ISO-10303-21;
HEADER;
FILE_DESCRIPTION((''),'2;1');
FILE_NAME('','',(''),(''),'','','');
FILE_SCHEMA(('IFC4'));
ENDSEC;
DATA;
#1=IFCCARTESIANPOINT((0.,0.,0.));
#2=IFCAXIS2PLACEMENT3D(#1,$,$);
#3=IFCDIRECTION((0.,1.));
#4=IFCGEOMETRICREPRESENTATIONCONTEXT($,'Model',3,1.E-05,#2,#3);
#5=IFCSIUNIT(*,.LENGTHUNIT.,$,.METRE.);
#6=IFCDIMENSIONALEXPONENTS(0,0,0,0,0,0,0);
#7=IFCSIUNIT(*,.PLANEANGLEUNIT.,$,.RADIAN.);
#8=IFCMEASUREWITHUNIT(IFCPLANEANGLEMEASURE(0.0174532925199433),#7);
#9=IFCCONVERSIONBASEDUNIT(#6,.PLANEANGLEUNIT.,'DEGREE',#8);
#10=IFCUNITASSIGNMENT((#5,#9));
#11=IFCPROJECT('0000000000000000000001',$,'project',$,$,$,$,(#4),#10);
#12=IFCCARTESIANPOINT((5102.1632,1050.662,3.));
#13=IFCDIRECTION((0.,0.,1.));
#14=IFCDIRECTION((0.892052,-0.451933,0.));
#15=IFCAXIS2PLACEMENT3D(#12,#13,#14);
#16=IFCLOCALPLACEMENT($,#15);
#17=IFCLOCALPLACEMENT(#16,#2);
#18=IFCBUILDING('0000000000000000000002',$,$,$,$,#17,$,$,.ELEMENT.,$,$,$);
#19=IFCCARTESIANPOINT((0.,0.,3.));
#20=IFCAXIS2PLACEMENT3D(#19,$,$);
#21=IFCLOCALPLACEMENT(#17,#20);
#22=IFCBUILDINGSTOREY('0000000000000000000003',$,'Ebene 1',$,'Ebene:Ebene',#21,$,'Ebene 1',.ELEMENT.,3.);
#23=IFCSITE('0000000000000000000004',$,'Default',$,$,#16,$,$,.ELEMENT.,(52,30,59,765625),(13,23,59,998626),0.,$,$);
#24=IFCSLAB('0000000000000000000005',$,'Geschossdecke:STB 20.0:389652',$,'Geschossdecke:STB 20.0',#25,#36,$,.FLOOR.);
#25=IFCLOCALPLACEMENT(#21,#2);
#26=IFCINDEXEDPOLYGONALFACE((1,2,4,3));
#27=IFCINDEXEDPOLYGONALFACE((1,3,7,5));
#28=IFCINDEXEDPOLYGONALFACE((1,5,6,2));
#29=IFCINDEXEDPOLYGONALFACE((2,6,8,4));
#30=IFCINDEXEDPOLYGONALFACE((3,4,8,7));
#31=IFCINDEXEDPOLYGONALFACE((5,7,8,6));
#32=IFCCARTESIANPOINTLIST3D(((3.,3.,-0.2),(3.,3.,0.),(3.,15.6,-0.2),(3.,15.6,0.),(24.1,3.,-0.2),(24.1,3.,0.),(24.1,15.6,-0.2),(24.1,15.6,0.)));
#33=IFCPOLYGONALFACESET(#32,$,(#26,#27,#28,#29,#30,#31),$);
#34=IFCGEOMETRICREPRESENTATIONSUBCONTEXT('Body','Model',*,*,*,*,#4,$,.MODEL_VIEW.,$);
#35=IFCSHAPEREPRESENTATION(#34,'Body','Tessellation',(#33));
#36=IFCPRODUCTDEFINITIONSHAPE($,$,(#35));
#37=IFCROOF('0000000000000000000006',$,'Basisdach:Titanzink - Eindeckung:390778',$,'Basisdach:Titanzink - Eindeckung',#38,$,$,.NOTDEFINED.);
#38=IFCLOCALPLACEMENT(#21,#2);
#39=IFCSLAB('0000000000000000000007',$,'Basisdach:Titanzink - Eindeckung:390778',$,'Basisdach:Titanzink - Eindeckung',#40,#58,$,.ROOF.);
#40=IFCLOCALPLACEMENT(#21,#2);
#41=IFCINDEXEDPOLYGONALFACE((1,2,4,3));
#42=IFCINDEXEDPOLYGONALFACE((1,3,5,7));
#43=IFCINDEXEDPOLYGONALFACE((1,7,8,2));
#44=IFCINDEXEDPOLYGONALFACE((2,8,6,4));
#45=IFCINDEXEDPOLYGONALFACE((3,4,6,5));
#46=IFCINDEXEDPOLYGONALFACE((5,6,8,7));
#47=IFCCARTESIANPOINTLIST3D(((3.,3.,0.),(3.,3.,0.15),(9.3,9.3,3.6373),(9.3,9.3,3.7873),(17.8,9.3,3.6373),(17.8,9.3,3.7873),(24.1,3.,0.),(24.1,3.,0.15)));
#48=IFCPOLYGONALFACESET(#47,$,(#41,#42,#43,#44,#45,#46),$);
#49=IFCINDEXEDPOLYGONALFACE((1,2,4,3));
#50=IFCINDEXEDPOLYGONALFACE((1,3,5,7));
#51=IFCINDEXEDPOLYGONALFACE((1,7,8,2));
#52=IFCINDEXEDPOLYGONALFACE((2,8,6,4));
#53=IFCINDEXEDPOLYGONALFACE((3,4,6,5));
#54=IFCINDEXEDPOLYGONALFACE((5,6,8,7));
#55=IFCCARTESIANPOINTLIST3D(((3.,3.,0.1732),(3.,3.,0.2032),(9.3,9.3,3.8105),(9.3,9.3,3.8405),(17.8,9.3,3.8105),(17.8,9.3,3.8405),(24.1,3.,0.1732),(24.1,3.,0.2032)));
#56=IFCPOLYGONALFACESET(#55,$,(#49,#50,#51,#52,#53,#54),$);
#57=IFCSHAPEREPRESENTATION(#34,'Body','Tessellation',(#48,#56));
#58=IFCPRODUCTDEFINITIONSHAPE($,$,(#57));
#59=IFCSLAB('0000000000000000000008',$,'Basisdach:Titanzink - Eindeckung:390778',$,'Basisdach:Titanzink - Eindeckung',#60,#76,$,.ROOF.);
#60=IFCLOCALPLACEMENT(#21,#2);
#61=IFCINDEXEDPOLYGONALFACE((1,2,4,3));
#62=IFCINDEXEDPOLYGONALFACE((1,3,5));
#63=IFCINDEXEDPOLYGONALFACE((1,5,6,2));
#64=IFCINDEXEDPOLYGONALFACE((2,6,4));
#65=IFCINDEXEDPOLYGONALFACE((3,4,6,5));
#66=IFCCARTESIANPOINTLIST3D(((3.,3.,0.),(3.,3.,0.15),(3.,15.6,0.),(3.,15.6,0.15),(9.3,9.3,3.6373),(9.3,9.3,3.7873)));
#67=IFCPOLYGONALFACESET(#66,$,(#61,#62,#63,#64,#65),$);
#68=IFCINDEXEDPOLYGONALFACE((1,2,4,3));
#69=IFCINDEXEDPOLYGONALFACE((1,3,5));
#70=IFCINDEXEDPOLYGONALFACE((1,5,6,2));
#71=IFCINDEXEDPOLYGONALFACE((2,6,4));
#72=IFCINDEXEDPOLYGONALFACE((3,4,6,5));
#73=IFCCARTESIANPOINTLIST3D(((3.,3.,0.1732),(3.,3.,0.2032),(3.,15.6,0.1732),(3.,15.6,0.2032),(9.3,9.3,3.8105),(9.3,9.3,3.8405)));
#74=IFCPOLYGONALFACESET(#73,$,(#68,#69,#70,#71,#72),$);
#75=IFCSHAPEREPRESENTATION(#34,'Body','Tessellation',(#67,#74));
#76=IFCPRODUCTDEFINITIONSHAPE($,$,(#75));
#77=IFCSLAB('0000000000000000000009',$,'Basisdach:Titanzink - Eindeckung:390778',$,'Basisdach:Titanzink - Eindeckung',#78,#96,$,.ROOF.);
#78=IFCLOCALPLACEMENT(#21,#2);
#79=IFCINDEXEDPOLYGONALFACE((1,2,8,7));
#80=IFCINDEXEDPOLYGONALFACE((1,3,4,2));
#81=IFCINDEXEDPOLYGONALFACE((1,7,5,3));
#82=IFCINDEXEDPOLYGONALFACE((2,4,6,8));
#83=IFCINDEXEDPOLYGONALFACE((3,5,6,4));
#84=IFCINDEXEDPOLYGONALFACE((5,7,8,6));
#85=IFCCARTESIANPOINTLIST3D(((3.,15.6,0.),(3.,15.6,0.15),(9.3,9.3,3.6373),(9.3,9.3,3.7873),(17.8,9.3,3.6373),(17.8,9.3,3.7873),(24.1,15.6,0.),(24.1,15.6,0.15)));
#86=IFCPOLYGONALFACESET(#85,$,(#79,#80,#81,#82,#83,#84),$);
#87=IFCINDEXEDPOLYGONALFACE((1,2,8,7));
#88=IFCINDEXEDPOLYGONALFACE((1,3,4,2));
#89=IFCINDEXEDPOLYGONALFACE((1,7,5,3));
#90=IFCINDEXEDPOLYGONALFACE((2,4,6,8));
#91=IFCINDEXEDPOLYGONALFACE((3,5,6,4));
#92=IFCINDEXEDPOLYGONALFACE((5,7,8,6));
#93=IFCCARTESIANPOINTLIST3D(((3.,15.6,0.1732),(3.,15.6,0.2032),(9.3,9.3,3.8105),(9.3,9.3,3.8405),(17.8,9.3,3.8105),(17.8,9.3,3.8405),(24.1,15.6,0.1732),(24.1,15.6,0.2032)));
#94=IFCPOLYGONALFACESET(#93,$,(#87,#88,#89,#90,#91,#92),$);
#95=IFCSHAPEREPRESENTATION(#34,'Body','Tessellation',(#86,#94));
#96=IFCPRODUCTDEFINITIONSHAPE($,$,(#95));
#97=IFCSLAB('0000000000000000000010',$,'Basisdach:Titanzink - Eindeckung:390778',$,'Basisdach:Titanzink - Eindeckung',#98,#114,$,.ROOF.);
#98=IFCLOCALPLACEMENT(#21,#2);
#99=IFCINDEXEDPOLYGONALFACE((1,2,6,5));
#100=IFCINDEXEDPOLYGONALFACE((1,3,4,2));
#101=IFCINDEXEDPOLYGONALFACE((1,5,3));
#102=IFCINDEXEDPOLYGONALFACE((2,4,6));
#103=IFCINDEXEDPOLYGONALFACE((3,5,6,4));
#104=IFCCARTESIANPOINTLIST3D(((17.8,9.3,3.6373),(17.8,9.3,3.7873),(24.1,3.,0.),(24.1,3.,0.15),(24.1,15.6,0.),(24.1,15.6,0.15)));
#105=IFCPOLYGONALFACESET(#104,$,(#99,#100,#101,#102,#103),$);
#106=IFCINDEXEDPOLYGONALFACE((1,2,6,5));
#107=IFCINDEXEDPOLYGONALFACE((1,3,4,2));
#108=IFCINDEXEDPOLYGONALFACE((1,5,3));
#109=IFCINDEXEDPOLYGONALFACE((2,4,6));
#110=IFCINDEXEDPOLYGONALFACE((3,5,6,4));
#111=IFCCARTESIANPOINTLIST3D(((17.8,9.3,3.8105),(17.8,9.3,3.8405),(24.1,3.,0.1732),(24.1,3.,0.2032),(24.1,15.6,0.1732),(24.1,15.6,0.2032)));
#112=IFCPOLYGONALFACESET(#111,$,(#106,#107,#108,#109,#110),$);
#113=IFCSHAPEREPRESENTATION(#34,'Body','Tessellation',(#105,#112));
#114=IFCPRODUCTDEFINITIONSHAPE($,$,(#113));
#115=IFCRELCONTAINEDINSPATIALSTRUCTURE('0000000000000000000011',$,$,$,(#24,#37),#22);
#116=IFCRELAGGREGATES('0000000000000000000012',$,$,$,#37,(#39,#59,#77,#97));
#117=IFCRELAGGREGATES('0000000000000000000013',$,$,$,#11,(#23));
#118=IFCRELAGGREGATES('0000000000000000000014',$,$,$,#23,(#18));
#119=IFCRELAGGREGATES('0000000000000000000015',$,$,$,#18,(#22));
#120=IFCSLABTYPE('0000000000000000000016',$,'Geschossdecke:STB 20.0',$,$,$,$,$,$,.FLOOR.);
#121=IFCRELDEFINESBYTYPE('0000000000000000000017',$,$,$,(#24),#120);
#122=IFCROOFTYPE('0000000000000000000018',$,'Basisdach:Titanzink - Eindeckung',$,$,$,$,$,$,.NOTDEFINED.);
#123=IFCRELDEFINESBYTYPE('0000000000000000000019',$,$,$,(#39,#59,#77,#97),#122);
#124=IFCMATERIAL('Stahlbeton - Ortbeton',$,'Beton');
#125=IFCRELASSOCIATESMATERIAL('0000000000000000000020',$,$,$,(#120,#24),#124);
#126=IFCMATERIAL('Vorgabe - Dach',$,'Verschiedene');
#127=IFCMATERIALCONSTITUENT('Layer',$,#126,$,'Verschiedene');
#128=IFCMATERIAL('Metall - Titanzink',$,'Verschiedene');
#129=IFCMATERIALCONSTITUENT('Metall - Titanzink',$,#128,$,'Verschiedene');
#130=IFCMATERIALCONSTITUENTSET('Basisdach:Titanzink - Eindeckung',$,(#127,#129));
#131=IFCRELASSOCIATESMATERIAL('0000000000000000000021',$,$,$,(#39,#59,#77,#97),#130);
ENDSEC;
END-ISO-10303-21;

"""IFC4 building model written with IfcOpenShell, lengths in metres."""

from ifc_helpers import new_model, entity, si_unit, converted_unit, direction, frame, origin, place, context, subcontext, project, spatial, indexed_curve, outline, extrude, material, constituent, constituent_set, type_object, element, aggregate, save


model = new_model("IFC4")

# Units and contexts
model_context = context("Model", 3, precision=1e-05, world=origin(), true_north=direction((0.0, 1.0)))
body_context = subcontext(model_context, "Body", "Model", "MODEL_VIEW")
ifc_project = project(units=[si_unit("LENGTHUNIT", "METRE"), converted_unit("PLANEANGLEUNIT", "DEGREE", entity("IfcPlaneAngleMeasure", 0.0174532925199433), si_unit("PLANEANGLEUNIT", "RADIAN"), dimensions=[0, 0, 0, 0, 0, 0, 0])], contexts=[model_context])

# Site, building, storey
site_placement = place(None, frame((5102.1632, 1050.662, 3.0), z_axis=(0.0, 0.0, 1.0), x_axis=(0.892052, -0.451933, 0.0)))
site = spatial("IfcSite", under=ifc_project, at=site_placement, Name="Default", CompositionType="ELEMENT", RefLatitude=(52, 30, 59, 765625), RefLongitude=(13, 23, 59, 998626), RefElevation=0.0)
building_placement = place(site_placement, origin())
building = spatial("IfcBuilding", under=site, at=building_placement, CompositionType="ELEMENT")
storey_placement = place(building_placement, frame((0.0, 0.0, 3.0)))
storey = spatial("IfcBuildingStorey", under=building, at=storey_placement, Name="Ebene 1", ObjectType="Ebene:Ebene", LongName="Ebene 1", CompositionType="ELEMENT", Elevation=3.0)

# Slab
ifc_material_1 = material(Name="Stahlbeton - Ortbeton", Category="Beton")
slab_type = type_object("IfcSlabType", Name="Geschossdecke:STB 20.0", PredefinedType="FLOOR", material=ifc_material_1)
slab_1_placement = place(storey_placement, origin())
element("IfcSlab", 1, at=slab_1_placement, inside=storey, type_object=slab_type, material=ifc_material_1, Name="Geschossdecke:STB 20.0:389652", ObjectType="Geschossdecke:STB 20.0", PredefinedType="FLOOR", context=body_context, shape_type="SweptSolid", body=[
    extrude(outline(indexed_curve([(-6.3, -10.55), (6.3, -10.55), (6.3, 10.55), (-6.3, 10.55), (-6.3, -10.55)], self_intersect=False)), frame((13.55, 9.3, 0.0), z_axis=(0.0, 0.0, -1.0), x_axis=(0.0, 1.0, 0.0)), (0.0, 0.0, 1.0), 0.2),
])

# Roof, slabs
roof_placement = place(storey_placement, frame((3.0, 3.0, 0.0)))
roof = element("IfcRoof", 2, at=roof_placement, inside=storey, Name="Basisdach:Titanzink - Eindeckung:390778", ObjectType="Basisdach:Titanzink - Eindeckung", PredefinedType="NOTDEFINED")
ifc_material_2 = material(Name="Vorgabe - Dach", Category="Verschiedene")
ifc_constituent_1 = constituent(ifc_material_2, Name="Layer", Category="Verschiedene")
ifc_material_3 = material(Name="Metall - Titanzink", Category="Verschiedene")
ifc_constituent_2 = constituent(ifc_material_3, Name="Metall - Titanzink", Category="Verschiedene")
ifc_constituent_set = constituent_set(constituents=[ifc_constituent_1, ifc_constituent_2], Name="Basisdach:Titanzink - Eindeckung")
roof_type = type_object("IfcRoofType", Name="Basisdach:Titanzink - Eindeckung", PredefinedType="NOTDEFINED")
slab_2_placement = place(roof_placement, origin())
slab_2 = element("IfcSlab", 3, at=slab_2_placement, type_object=roof_type, material=ifc_constituent_set, Name="Basisdach:Titanzink - Eindeckung:390778", ObjectType="Basisdach:Titanzink - Eindeckung", PredefinedType="ROOF", context=body_context, shape_type="SweptSolid", body=[
    extrude(outline(indexed_curve([(4.25, 3.6373), (-4.25, 3.6373), (-10.55, -3.6373), (10.55, -3.6373), (4.25, 3.6373)], self_intersect=False)), frame((10.55, 3.15, 1.8187), z_axis=(0.0, -0.5, 0.866025), x_axis=(1.0, 0.0, 0.0)), (0.0, 0.5, 0.866025), 0.15),
    extrude(outline(indexed_curve([(4.25, 3.6373), (-4.25, 3.6373), (-10.55, -3.6373), (10.55, -3.6373), (4.25, 3.6373)], self_intersect=False)), frame((10.55, 3.15, 1.9919), z_axis=(0.0, -0.5, 0.866025), x_axis=(1.0, 0.0, 0.0)), (0.0, 0.5, 0.866025), 0.03),
])
slab_3_placement = place(roof_placement, origin())
slab_3 = element("IfcSlab", 4, at=slab_3_placement, type_object=roof_type, material=ifc_constituent_set, Name="Basisdach:Titanzink - Eindeckung:390778", ObjectType="Basisdach:Titanzink - Eindeckung", PredefinedType="ROOF", context=body_context, shape_type="SweptSolid", body=[
    extrude(outline(indexed_curve([(-3.6373, 6.3), (-3.6373, -6.3), (3.6373, 0.0), (-3.6373, 6.3)], self_intersect=False)), frame((3.15, 6.3, 1.8187), z_axis=(-0.5, 0.0, 0.866025), x_axis=(0.866025, 0.0, 0.5)), (0.5, 0.0, 0.866025), 0.15),
    extrude(outline(indexed_curve([(-3.6373, 6.3), (-3.6373, -6.3), (3.6373, 0.0), (-3.6373, 6.3)], self_intersect=False)), frame((3.15, 6.3, 1.9919), z_axis=(-0.5, 0.0, 0.866025), x_axis=(0.866025, 0.0, 0.5)), (0.5, 0.0, 0.866025), 0.03),
])
slab_4_placement = place(roof_placement, origin())
slab_4 = element("IfcSlab", 5, at=slab_4_placement, type_object=roof_type, material=ifc_constituent_set, Name="Basisdach:Titanzink - Eindeckung:390778", ObjectType="Basisdach:Titanzink - Eindeckung", PredefinedType="ROOF", context=body_context, shape_type="SweptSolid", body=[
    extrude(outline(indexed_curve([(10.55, 3.6373), (-10.55, 3.6373), (-4.25, -3.6373), (4.25, -3.6373), (10.55, 3.6373)], self_intersect=False)), frame((10.55, 9.45, 1.8187), z_axis=(0.0, 0.5, 0.866025), x_axis=(1.0, 0.0, 0.0)), (0.0, -0.5, 0.866025), 0.15),
    extrude(outline(indexed_curve([(10.55, 3.6373), (-10.55, 3.6373), (-4.25, -3.6373), (4.25, -3.6373), (10.55, 3.6373)], self_intersect=False)), frame((10.55, 9.45, 1.9919), z_axis=(0.0, 0.5, 0.866025), x_axis=(1.0, 0.0, 0.0)), (0.0, -0.5, 0.866025), 0.03),
])
slab_5_placement = place(roof_placement, origin())
slab_5 = element("IfcSlab", 6, at=slab_5_placement, type_object=roof_type, material=ifc_constituent_set, Name="Basisdach:Titanzink - Eindeckung:390778", ObjectType="Basisdach:Titanzink - Eindeckung", PredefinedType="ROOF", context=body_context, shape_type="SweptSolid", body=[
    extrude(outline(indexed_curve([(3.6373, -6.3), (3.6373, 6.3), (-3.6373, 0.0), (3.6373, -6.3)], self_intersect=False)), frame((17.95, 6.3, 1.8187), z_axis=(0.5, 0.0, 0.866025), x_axis=(0.866025, 0.0, -0.5)), (-0.5, 0.0, 0.866025), 0.15),
    extrude(outline(indexed_curve([(3.6373, -6.3), (3.6373, 6.3), (-3.6373, 0.0), (3.6373, -6.3)], self_intersect=False)), frame((17.95, 6.3, 1.9919), z_axis=(0.5, 0.0, 0.866025), x_axis=(0.866025, 0.0, -0.5)), (-0.5, 0.0, 0.866025), 0.03),
])
aggregate(roof, [slab_2, slab_3, slab_4, slab_5])

save(model, "model.ifc")
